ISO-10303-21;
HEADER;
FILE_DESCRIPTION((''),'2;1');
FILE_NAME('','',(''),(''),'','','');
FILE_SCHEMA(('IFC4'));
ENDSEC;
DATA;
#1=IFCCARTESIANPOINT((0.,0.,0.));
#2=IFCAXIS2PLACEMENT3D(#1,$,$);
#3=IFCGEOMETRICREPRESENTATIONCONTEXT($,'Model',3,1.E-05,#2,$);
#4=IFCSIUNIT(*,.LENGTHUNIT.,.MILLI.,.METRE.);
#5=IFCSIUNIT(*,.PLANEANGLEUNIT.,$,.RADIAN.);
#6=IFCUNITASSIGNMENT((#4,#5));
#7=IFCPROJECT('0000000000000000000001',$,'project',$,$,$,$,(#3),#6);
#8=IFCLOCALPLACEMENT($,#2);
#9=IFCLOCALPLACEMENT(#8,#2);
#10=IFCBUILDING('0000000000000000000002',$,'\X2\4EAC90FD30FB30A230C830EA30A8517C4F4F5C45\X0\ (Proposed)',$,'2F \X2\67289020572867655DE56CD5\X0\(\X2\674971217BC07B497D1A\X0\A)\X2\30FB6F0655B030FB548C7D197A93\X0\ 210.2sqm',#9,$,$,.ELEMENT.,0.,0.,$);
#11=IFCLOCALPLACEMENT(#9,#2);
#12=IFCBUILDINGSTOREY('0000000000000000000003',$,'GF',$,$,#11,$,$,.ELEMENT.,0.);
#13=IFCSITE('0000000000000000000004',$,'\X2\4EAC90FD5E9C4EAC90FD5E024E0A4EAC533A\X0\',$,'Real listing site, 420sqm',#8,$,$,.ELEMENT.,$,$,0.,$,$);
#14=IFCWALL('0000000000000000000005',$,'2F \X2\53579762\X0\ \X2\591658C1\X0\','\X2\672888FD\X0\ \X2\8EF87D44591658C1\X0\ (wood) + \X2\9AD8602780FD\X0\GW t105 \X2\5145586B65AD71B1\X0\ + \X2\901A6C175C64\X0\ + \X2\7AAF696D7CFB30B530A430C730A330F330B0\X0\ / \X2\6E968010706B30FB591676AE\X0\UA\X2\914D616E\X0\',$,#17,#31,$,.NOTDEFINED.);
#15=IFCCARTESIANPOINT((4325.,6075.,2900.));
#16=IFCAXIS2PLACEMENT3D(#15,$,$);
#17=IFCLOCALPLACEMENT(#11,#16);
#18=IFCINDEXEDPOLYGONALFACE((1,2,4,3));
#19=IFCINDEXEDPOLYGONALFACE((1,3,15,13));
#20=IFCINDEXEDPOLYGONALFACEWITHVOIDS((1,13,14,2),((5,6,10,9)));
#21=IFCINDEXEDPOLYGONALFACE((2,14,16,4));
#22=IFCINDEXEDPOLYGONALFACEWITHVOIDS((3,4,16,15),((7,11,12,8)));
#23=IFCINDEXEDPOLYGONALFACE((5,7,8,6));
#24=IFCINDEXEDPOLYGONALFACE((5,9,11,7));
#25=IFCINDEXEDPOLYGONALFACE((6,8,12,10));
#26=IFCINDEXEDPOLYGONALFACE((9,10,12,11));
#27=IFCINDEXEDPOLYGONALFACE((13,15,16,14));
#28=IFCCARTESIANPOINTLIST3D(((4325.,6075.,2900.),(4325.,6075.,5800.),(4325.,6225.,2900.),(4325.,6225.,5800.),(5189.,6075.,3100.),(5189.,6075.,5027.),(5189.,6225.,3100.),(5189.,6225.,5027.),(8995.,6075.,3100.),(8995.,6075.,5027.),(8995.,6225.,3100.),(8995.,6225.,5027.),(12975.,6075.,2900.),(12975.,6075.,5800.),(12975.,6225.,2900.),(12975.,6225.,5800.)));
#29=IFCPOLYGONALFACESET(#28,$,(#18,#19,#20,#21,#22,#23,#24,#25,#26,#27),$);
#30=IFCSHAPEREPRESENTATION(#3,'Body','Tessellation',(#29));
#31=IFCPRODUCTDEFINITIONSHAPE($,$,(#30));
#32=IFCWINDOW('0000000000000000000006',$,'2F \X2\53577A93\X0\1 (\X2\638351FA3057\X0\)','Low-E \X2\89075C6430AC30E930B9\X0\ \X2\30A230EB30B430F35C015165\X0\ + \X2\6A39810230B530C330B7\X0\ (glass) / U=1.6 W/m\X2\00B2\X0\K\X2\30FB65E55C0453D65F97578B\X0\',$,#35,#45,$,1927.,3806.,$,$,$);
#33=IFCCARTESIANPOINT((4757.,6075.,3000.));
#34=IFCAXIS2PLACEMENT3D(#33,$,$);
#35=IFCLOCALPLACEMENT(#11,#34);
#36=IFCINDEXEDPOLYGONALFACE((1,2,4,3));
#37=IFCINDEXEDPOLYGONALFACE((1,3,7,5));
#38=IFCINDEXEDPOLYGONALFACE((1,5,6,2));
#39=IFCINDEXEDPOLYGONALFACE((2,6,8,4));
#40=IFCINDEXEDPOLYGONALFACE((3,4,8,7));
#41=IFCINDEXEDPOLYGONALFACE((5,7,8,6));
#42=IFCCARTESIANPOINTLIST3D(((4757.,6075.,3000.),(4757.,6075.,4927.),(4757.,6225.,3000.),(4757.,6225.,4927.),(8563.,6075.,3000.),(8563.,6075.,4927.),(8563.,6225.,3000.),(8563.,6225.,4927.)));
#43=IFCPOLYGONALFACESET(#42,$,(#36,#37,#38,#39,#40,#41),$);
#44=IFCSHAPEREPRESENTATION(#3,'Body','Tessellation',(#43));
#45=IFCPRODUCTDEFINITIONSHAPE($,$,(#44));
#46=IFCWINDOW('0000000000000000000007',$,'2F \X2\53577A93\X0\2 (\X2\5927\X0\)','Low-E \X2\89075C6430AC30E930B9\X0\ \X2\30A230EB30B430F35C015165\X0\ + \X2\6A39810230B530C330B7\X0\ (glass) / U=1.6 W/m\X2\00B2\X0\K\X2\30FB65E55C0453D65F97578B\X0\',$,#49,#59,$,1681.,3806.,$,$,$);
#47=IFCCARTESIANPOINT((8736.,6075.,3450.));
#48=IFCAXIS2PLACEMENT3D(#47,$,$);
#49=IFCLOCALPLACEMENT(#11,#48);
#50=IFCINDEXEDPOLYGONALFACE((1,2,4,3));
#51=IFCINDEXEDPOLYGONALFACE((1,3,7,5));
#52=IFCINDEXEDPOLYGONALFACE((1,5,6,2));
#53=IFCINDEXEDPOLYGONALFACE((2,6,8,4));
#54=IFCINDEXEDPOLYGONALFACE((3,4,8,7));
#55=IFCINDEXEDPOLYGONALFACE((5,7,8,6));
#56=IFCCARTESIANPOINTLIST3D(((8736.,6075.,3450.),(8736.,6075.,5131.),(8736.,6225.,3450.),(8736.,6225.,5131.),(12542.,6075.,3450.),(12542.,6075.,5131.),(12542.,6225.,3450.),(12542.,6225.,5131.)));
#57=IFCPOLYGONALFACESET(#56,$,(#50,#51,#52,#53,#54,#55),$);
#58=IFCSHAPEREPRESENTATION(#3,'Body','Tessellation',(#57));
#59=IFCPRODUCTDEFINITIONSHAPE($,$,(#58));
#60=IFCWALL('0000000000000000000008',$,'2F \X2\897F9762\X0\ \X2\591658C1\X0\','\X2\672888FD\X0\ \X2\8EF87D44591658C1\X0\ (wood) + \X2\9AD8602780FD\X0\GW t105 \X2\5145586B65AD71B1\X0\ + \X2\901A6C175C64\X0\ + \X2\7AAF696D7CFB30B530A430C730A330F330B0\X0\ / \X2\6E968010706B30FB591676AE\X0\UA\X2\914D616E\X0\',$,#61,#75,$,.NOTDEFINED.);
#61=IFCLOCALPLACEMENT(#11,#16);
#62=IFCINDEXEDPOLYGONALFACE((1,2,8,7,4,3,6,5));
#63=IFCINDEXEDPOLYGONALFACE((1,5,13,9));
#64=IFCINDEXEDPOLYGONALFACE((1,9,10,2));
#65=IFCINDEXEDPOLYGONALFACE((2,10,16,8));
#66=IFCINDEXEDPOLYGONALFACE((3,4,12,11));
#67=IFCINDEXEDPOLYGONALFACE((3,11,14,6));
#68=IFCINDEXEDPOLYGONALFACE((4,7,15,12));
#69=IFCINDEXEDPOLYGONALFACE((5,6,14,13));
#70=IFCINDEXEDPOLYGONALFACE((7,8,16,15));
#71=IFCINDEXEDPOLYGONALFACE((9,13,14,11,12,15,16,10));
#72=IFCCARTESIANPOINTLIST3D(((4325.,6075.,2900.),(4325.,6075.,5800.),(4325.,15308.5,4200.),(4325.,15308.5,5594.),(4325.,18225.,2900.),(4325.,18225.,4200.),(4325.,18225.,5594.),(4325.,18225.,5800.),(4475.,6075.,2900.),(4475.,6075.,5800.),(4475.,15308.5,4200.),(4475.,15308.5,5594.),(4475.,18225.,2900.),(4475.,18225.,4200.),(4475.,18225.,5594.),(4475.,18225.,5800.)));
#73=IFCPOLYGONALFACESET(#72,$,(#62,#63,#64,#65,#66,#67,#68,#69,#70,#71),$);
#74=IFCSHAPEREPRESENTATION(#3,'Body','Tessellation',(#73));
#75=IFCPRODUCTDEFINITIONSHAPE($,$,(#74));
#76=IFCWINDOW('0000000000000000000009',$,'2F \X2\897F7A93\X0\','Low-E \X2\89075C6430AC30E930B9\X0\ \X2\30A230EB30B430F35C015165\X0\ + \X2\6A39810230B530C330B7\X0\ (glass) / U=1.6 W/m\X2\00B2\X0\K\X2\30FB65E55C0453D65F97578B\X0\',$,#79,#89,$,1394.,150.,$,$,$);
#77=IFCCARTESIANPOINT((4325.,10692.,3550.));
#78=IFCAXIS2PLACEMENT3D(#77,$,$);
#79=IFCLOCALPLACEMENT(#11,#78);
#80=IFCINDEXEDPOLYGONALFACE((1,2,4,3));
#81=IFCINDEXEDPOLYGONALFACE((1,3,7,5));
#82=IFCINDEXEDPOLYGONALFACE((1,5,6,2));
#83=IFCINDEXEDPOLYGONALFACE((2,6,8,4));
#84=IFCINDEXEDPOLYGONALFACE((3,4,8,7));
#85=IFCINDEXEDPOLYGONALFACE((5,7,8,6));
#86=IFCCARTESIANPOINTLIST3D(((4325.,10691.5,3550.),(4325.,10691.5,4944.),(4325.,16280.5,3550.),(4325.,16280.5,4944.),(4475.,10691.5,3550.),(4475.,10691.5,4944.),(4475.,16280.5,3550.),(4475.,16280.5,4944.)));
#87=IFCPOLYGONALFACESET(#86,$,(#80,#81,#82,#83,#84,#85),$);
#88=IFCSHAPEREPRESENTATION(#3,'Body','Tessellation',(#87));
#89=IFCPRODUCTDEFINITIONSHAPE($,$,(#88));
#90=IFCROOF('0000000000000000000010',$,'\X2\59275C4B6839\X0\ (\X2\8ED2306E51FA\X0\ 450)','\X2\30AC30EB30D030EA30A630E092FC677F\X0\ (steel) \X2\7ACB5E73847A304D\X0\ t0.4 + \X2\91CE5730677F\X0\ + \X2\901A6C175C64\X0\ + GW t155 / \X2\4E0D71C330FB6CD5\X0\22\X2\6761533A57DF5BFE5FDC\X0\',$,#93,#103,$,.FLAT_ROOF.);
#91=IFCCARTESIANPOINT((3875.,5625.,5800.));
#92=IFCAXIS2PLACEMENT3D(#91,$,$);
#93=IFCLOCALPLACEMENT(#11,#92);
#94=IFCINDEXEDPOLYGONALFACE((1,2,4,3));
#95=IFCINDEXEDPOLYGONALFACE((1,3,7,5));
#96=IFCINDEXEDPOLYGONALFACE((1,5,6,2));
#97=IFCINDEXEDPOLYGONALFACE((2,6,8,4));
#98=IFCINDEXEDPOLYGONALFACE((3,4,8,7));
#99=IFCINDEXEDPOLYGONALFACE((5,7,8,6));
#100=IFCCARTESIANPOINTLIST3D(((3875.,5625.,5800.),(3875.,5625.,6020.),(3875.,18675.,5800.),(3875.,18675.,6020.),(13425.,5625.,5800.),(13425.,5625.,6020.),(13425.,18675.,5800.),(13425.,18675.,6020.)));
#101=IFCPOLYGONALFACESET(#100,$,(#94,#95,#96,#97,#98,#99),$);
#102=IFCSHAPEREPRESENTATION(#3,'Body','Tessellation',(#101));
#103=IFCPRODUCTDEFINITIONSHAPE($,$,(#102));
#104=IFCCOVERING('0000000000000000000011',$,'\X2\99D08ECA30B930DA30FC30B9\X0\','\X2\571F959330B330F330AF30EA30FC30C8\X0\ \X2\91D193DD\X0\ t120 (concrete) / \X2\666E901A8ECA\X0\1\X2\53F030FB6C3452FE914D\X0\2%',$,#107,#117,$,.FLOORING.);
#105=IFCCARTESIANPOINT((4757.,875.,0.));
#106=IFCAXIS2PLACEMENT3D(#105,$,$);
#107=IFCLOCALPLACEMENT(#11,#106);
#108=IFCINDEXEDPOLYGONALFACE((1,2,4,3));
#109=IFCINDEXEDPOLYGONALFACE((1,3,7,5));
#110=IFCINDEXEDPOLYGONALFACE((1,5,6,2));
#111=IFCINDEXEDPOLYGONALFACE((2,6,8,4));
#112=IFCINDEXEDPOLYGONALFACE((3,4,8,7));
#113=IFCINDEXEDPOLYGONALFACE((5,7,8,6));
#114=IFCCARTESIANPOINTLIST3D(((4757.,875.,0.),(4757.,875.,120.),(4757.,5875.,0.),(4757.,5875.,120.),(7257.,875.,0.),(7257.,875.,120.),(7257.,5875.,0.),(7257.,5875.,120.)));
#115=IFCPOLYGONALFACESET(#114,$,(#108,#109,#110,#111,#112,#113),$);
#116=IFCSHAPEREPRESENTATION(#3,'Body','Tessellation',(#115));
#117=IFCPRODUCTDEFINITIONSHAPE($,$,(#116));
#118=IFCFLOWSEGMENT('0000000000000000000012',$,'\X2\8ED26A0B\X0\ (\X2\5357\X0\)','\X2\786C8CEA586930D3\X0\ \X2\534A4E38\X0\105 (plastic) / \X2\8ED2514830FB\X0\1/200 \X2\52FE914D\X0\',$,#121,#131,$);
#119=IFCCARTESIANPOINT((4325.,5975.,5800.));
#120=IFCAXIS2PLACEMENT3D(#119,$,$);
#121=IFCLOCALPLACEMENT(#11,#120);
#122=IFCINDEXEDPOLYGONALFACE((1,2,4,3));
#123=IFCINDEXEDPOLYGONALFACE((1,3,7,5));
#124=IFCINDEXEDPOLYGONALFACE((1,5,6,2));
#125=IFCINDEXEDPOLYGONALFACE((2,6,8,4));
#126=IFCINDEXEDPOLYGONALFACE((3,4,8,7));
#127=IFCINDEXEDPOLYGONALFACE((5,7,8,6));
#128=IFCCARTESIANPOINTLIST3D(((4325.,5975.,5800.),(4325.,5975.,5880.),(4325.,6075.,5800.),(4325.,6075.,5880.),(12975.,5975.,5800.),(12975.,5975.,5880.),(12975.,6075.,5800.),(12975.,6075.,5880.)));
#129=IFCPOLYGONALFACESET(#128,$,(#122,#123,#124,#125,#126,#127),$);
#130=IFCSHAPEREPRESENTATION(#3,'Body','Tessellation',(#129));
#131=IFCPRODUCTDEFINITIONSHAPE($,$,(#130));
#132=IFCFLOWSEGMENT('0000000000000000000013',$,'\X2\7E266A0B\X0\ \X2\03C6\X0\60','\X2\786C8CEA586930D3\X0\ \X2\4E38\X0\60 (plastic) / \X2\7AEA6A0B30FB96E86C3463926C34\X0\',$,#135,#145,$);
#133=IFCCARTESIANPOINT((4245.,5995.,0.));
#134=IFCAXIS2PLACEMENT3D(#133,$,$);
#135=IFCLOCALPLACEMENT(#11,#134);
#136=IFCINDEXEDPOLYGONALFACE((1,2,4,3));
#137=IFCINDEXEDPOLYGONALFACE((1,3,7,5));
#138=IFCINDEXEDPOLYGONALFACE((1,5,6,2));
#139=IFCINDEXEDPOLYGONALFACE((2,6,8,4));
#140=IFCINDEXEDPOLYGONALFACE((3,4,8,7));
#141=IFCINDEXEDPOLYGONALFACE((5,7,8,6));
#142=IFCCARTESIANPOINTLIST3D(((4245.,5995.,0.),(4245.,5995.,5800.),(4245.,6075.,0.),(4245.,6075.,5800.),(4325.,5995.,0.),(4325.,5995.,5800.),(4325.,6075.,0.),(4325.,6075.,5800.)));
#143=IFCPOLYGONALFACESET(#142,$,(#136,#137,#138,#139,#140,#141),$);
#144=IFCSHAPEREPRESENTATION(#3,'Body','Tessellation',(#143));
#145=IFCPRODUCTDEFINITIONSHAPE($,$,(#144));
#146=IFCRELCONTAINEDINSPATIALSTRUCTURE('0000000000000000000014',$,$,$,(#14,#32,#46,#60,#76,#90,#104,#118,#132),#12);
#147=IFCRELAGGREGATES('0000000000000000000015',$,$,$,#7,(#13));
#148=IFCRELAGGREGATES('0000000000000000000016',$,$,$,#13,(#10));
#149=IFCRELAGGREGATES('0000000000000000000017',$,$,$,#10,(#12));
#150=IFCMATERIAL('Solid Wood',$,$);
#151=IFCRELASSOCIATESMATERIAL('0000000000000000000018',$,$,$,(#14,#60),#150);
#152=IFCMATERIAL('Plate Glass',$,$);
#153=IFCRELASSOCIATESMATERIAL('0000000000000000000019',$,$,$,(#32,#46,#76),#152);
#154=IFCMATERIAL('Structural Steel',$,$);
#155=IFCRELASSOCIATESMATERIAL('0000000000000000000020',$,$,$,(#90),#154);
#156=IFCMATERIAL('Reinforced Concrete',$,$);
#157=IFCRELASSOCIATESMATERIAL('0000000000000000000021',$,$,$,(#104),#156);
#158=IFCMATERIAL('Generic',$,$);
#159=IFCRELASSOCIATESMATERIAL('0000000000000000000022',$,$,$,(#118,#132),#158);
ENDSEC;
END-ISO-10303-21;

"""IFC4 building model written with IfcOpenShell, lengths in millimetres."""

from ifc_helpers import new_model, si_unit, frame, frame_2d, origin, place, context, project, spatial, rectangle, extrude, material, element, fill, save


model = new_model("IFC4")

# Units and contexts
model_context = context("Model", 3, precision=1e-05, world=origin())
ifc_project = project(units=[si_unit("LENGTHUNIT", "METRE", prefix="MILLI"), si_unit("PLANEANGLEUNIT", "RADIAN")], contexts=[model_context])

# Site, building, storey
site_placement = place(None, origin())
site = spatial("IfcSite", under=ifc_project, at=site_placement, Name="京都府京都市上京区", ObjectType="Real listing site, 420sqm", CompositionType="ELEMENT", RefElevation=0.0)
building_placement = place(site_placement, origin())
building = spatial("IfcBuilding", under=site, at=building_placement, Name="京都・アトリエ兼住居 (Proposed)", ObjectType="2F 木造在来工法(杉無節等級A)・漆喰・和紙窓 210.2sqm", CompositionType="ELEMENT", ElevationOfRefHeight=0.0, ElevationOfTerrain=0.0)
storey_placement = place(building_placement, origin())
storey = spatial("IfcBuildingStorey", under=building, at=storey_placement, Name="GF", CompositionType="ELEMENT", Elevation=0.0)

# Shared definitions
ifc_material_1 = material(Name="Solid Wood")

# Shared definitions
ifc_material_2 = material(Name="Reinforced Concrete")

# Shared definitions
ifc_material_3 = material(Name="Plate Glass")

# Wall, openings, windows
wall_1_placement = place(storey_placement, frame((4325.0, 6075.0, 2900.0)))
wall_1 = element("IfcWall", 1, at=wall_1_placement, inside=storey, material=ifc_material_1, Name="2F 南面 外壁", Description="木製 軸組外壁 (wood) + 高性能GW t105 充填断熱 + 通気層 + 窯業系サイディング / 準耐火・外皮UA配慮", PredefinedType="NOTDEFINED", context=model_context, shape_type="SweptSolid", body=[
    extrude(rectangle(XDim=8650.0, YDim=150.0, at=frame_2d((4325.0, 75.0))), frame((4325.0, 6075.0, 2900.0)), (0.0, 0.0, 1.0), 2900.0),
])
opening_1_placement = place(storey_placement, frame((4757.0, 6075.0, 3000.0)))
opening_1 = element("IfcOpeningElement", 2, at=opening_1_placement, cuts=wall_1, PredefinedType="NOTDEFINED", context=model_context, shape_type="SweptSolid", body=[
    extrude(rectangle(XDim=3806.0, YDim=150.0, at=frame_2d((1903.0, 75.0))), frame((4757.0, 6075.0, 3000.0)), (0.0, 0.0, 1.0), 1927.0),
])
opening_2_placement = place(storey_placement, frame((8736.0, 6075.0, 3450.0)))
opening_2 = element("IfcOpeningElement", 3, at=opening_2_placement, cuts=wall_1, PredefinedType="NOTDEFINED", context=model_context, shape_type="SweptSolid", body=[
    extrude(rectangle(XDim=3806.0, YDim=150.0, at=frame_2d((1903.0, 75.0))), frame((8736.0, 6075.0, 3450.0)), (0.0, 0.0, 1.0), 1681.0),
])
window_1_placement = place(storey_placement, frame((4757.0, 6075.0, 3000.0)))
window_1 = element("IfcWindow", 4, at=window_1_placement, inside=storey, material=ifc_material_3, Name="2F 南窓1 (掃出し)", Description="Low-E 複層ガラス アルゴン封入 + 樹脂サッシ (glass) / U=1.6 W/m²K・日射取得型", OverallHeight=1927.0, OverallWidth=3806.0, context=model_context, shape_type="SweptSolid", body=[
    extrude(rectangle(XDim=3806.0, YDim=150.0, at=frame_2d((1903.0, 75.0))), frame((4757.0, 6075.0, 3000.0)), (0.0, 0.0, 1.0), 1927.0),
])
fill(opening_1, window_1)
window_2_placement = place(storey_placement, frame((8736.0, 6075.0, 3450.0)))
window_2 = element("IfcWindow", 5, at=window_2_placement, inside=storey, material=ifc_material_3, Name="2F 南窓2 (大)", Description="Low-E 複層ガラス アルゴン封入 + 樹脂サッシ (glass) / U=1.6 W/m²K・日射取得型", OverallHeight=1681.0, OverallWidth=3806.0, context=model_context, shape_type="SweptSolid", body=[
    extrude(rectangle(XDim=3806.0, YDim=150.0, at=frame_2d((1903.0, 75.0))), frame((8736.0, 6075.0, 3450.0)), (0.0, 0.0, 1.0), 1681.0),
])
fill(opening_2, window_2)

# Wall, opening, window
wall_2_placement = place(storey_placement, frame((4325.0, 6075.0, 2900.0)))
wall_2 = element("IfcWall", 6, at=wall_2_placement, inside=storey, material=ifc_material_1, Name="2F 西面 外壁", Description="木製 軸組外壁 (wood) + 高性能GW t105 充填断熱 + 通気層 + 窯業系サイディング / 準耐火・外皮UA配慮", PredefinedType="NOTDEFINED", context=model_context, shape_type="SweptSolid", body=[
    extrude(rectangle(XDim=150.0, YDim=12150.0, at=frame_2d((75.0, 6075.0))), frame((4325.0, 6075.0, 2900.0)), (0.0, 0.0, 1.0), 2900.0),
])
opening_3_placement = place(storey_placement, frame((4325.0, 10692.0, 3550.0)))
opening_3 = element("IfcOpeningElement", 7, at=opening_3_placement, cuts=wall_2, PredefinedType="NOTDEFINED", context=model_context, shape_type="SweptSolid", body=[
    extrude(rectangle(XDim=150.0, YDim=5589.0, at=frame_2d((75.0, 2794.0))), frame((4325.0, 10692.0, 3550.0)), (0.0, 0.0, 1.0), 1394.0),
])
window_3_placement = place(storey_placement, frame((4325.0, 10692.0, 3550.0)))
window_3 = element("IfcWindow", 8, at=window_3_placement, inside=storey, material=ifc_material_3, Name="2F 西窓", Description="Low-E 複層ガラス アルゴン封入 + 樹脂サッシ (glass) / U=1.6 W/m²K・日射取得型", OverallHeight=1394.0, OverallWidth=150.0, context=model_context, shape_type="SweptSolid", body=[
    extrude(rectangle(XDim=150.0, YDim=5589.0, at=frame_2d((75.0, 2794.0))), frame((4325.0, 10692.0, 3550.0)), (0.0, 0.0, 1.0), 1394.0),
])
fill(opening_3, window_3)

# Roof
ifc_material_4 = material(Name="Structural Steel")
roof_placement = place(storey_placement, frame((3875.0, 5625.0, 5800.0)))
element("IfcRoof", 9, at=roof_placement, inside=storey, material=ifc_material_4, Name="大屋根 (軒の出 450)", Description="ガルバリウム鋼板 (steel) 立平葺き t0.4 + 野地板 + 通気層 + GW t155 / 不燃・法22条区域対応", PredefinedType="FLAT_ROOF", context=model_context, shape_type="SweptSolid", body=[
    extrude(rectangle(XDim=9550.0, YDim=13050.0, at=frame_2d((4775.0, 6525.0))), frame((3875.0, 5625.0, 5800.0)), (0.0, 0.0, 1.0), 220.0),
])

# Covering
covering_placement = place(storey_placement, frame((4757.0, 875.0, 0.0)))
element("IfcCovering", 10, at=covering_placement, inside=storey, material=ifc_material_2, Name="駐車スペース", Description="土間コンクリート 金鏝 t120 (concrete) / 普通車1台・水勾配2%", PredefinedType="FLOORING", context=model_context, shape_type="SweptSolid", body=[
    extrude(rectangle(XDim=2500.0, YDim=5000.0, at=frame_2d((1250.0, 2500.0))), frame((4757.0, 875.0, 0.0)), (0.0, 0.0, 1.0), 120.0),
])

# Flow segments
ifc_material_5 = material(Name="Generic")
flow_segment_1_placement = place(storey_placement, frame((4325.0, 5975.0, 5800.0)))
element("IfcFlowSegment", 11, at=flow_segment_1_placement, inside=storey, material=ifc_material_5, Name="軒樋 (南)", Description="硬質塩ビ 半丸105 (plastic) / 軒先・1/200 勾配", context=model_context, shape_type="SweptSolid", body=[
    extrude(rectangle(XDim=8650.0, YDim=100.0, at=frame_2d((4325.0, 50.0))), frame((4325.0, 5975.0, 5800.0)), (0.0, 0.0, 1.0), 80.0),
])
flow_segment_2_placement = place(storey_placement, frame((4245.0, 5995.0, 0.0)))
element("IfcFlowSegment", 12, at=flow_segment_2_placement, inside=storey, material=ifc_material_5, Name="縦樋 φ60", Description="硬質塩ビ 丸60 (plastic) / 竪樋・雨水排水", context=model_context, shape_type="SweptSolid", body=[
    extrude(rectangle(XDim=80.0, YDim=80.0, at=frame_2d((40.0, 40.0))), frame((4245.0, 5995.0, 0.0)), (0.0, 0.0, 1.0), 5800.0),
])

save(model, "model.ifc")
